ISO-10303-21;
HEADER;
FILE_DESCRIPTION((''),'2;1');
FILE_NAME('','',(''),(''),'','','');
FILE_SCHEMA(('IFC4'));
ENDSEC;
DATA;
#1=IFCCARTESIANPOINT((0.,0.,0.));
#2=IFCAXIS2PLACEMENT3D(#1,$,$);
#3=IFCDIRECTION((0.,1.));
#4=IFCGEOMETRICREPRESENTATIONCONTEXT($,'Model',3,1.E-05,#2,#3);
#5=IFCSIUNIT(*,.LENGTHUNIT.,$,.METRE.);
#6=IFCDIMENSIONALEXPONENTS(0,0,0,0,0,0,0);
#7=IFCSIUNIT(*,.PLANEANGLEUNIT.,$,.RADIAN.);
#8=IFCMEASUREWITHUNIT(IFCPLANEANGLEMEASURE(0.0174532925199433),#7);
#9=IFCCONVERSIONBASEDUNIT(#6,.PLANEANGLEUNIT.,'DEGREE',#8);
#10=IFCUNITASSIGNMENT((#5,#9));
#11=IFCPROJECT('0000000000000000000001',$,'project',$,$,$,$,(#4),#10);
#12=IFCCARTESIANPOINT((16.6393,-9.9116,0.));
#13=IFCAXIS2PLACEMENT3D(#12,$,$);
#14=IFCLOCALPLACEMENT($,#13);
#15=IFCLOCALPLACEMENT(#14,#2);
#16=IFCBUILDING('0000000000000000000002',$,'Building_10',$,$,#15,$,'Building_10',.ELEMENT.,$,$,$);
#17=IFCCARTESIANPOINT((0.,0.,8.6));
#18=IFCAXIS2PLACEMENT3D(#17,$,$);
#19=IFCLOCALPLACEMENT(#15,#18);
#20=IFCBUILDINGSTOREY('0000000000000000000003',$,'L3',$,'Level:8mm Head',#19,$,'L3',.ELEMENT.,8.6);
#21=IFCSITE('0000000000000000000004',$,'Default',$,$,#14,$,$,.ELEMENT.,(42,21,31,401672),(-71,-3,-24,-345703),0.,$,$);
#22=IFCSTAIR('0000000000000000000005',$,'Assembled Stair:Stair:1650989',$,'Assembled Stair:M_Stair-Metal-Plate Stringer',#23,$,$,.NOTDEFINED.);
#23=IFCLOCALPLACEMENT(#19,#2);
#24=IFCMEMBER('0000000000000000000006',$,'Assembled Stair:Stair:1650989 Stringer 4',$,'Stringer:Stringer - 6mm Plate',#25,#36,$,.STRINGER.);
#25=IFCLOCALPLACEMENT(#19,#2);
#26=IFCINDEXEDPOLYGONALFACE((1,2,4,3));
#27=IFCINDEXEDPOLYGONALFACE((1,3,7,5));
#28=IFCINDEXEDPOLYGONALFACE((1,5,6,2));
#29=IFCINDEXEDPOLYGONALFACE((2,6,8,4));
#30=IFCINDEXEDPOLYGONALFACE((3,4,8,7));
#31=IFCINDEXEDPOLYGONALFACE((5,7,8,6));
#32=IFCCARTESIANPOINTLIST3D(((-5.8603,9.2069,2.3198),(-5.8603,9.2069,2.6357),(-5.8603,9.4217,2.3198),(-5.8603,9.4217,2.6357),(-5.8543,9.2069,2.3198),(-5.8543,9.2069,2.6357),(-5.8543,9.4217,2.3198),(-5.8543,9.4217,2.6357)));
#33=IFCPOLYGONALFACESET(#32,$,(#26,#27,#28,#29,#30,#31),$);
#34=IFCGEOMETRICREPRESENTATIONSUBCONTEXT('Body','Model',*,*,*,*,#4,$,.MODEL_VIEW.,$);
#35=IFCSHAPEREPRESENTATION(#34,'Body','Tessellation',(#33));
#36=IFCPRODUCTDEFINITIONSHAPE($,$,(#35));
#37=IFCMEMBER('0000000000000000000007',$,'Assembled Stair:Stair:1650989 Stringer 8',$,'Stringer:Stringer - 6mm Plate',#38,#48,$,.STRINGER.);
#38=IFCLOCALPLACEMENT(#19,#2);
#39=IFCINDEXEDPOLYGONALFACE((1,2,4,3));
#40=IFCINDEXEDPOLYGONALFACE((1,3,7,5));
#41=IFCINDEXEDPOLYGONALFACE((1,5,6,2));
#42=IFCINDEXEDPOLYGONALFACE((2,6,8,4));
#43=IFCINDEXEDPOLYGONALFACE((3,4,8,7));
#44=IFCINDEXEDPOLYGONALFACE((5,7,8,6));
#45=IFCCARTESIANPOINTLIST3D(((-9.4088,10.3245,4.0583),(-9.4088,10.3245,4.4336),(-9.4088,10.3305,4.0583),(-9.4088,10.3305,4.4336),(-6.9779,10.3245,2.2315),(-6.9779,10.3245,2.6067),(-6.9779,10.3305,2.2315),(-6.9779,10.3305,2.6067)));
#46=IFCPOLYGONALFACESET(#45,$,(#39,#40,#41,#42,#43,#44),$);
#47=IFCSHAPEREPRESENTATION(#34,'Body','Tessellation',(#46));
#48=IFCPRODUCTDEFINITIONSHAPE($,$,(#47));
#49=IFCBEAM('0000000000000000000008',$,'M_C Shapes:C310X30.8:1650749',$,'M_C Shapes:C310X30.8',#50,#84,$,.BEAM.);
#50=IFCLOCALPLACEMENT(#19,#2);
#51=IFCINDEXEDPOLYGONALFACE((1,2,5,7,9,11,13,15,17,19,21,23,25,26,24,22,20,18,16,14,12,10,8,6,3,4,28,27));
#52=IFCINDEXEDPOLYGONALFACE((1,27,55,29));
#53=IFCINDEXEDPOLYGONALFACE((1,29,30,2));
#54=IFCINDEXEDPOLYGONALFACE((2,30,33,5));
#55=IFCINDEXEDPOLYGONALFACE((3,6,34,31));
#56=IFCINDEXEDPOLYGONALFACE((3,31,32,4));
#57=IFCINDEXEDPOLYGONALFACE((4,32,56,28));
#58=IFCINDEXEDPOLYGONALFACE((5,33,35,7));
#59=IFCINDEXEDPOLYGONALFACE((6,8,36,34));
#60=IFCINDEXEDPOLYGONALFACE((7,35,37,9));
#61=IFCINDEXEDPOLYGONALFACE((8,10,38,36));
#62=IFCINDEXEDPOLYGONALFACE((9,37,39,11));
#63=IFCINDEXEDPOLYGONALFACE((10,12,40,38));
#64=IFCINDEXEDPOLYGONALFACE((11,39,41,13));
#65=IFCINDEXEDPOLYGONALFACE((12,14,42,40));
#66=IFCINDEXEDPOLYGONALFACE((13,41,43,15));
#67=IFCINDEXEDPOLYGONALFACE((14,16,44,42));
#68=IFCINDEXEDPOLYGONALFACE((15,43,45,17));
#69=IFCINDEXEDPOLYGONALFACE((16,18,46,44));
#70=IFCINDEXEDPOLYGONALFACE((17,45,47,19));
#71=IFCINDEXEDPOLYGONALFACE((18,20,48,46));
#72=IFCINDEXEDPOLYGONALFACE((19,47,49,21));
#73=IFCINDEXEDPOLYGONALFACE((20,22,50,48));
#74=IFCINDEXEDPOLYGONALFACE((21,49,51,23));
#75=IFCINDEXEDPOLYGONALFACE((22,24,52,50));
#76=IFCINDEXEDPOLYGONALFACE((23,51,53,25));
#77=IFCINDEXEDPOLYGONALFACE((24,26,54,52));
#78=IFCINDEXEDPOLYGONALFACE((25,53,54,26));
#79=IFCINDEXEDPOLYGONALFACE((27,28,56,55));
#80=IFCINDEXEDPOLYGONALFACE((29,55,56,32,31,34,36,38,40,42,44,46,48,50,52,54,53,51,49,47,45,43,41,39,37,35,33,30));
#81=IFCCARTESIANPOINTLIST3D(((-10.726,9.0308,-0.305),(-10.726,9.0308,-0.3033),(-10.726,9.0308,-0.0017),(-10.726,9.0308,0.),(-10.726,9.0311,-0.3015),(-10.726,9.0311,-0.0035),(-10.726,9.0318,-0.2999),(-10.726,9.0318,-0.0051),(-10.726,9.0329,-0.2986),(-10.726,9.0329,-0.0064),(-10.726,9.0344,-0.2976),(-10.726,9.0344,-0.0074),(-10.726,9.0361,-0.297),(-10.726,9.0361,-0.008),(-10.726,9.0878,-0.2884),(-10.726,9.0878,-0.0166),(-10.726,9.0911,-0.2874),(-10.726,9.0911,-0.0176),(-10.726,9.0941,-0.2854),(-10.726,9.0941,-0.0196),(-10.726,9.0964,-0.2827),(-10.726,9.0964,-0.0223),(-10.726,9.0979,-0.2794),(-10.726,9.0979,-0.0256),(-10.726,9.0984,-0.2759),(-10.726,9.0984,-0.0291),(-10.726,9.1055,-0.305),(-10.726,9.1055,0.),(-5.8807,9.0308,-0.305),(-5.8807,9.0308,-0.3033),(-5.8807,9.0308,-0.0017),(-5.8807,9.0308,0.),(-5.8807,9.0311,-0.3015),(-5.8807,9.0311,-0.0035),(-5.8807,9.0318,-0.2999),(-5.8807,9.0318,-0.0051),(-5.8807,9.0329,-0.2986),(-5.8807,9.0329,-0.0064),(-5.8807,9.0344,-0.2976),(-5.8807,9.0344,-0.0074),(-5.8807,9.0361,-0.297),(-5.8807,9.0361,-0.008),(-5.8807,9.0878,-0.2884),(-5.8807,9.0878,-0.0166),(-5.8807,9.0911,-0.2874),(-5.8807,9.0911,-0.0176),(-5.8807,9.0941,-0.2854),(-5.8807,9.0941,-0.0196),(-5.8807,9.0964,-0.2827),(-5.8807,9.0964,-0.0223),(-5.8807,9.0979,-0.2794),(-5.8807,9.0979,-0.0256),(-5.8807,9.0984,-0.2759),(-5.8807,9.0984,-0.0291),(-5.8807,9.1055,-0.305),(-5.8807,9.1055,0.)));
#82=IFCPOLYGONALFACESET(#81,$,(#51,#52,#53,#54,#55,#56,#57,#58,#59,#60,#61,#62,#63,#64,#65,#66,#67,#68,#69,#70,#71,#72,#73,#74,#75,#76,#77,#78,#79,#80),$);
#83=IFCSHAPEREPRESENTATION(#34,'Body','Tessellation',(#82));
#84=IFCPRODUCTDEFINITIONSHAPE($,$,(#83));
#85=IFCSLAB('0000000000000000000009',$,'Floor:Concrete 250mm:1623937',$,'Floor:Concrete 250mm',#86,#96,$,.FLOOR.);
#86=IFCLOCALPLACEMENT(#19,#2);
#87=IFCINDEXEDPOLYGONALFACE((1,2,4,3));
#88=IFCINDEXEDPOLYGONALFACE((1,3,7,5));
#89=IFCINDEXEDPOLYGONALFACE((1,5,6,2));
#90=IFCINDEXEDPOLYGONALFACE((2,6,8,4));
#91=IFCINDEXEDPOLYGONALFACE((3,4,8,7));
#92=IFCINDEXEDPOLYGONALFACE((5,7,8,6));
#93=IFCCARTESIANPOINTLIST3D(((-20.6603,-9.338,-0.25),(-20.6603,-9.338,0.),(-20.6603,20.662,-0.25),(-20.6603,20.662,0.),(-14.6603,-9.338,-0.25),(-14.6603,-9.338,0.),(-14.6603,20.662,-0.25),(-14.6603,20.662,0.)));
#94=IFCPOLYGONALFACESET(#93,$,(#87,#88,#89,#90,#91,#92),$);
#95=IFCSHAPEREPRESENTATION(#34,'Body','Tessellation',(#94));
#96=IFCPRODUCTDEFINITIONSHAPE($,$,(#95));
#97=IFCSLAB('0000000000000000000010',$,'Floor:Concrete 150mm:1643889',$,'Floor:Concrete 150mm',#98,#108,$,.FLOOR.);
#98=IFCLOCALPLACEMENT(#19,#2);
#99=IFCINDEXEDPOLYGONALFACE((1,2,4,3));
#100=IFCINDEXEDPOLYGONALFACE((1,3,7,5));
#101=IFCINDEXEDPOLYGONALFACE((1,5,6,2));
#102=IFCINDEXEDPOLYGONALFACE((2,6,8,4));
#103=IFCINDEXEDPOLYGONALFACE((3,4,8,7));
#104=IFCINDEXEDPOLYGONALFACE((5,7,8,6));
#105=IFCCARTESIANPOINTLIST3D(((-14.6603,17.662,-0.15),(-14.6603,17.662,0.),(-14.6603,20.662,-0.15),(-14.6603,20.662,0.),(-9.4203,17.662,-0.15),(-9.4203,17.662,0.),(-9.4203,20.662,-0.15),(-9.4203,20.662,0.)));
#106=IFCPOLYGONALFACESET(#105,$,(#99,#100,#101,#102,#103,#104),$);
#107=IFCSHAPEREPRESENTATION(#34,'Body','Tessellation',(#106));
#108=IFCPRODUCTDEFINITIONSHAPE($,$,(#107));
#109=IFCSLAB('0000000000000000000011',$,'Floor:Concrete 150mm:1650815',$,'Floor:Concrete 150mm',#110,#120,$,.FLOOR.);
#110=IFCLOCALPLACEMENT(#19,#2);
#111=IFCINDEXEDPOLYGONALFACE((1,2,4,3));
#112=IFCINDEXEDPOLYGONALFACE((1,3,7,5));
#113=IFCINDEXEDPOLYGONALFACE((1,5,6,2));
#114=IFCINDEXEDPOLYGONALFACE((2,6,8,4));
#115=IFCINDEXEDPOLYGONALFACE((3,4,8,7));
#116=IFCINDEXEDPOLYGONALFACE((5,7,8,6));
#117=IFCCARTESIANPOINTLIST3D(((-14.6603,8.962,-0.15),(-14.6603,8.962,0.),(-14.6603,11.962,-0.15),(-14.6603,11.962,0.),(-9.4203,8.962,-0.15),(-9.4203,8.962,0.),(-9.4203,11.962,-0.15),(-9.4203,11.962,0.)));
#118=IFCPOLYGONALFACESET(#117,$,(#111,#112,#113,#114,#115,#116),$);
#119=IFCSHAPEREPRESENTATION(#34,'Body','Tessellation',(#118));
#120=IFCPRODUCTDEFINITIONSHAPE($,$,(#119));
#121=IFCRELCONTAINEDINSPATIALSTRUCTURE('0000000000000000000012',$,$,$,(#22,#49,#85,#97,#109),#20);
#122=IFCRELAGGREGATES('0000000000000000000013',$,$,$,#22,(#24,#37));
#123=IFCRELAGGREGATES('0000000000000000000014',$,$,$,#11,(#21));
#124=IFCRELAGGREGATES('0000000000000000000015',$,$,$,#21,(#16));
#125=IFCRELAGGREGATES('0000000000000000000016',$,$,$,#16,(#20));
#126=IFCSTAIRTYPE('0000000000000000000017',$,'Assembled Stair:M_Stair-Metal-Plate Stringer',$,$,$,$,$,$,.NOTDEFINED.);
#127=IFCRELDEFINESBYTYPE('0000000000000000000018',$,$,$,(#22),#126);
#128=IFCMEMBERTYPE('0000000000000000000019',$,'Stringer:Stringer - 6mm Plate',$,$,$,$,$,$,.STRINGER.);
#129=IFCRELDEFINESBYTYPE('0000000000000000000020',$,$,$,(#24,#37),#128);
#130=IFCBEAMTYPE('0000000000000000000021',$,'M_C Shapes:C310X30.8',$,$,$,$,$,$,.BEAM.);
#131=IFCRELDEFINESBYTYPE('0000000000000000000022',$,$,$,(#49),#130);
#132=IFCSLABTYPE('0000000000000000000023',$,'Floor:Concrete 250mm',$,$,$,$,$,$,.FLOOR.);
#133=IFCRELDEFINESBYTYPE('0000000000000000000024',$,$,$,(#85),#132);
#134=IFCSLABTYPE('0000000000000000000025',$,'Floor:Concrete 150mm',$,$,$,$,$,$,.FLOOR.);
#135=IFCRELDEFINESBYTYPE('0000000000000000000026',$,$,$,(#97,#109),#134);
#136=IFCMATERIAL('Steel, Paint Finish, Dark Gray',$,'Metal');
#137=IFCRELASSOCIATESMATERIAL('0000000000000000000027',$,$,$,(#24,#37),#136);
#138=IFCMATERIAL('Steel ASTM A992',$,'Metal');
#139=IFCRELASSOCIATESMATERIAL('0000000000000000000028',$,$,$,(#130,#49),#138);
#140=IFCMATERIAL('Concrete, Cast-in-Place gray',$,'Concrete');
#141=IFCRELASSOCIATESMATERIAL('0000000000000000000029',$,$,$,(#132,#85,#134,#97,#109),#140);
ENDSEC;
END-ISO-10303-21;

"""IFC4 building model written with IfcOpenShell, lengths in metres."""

from ifc_helpers import new_model, entity, si_unit, converted_unit, direction, frame, origin, place, context, subcontext, project, spatial, line, arc, indexed_curve, outline, extrude, source, transform, mapped, material, type_object, type_shapes, element, aggregate, save


model = new_model("IFC4")

# Units and contexts
model_context = context("Model", 3, precision=1e-05, world=origin(), true_north=direction((0.0, 1.0)))
body_context = subcontext(model_context, "Body", "Model", "MODEL_VIEW")
ifc_project = project(units=[si_unit("LENGTHUNIT", "METRE"), converted_unit("PLANEANGLEUNIT", "DEGREE", entity("IfcPlaneAngleMeasure", 0.0174532925199433), si_unit("PLANEANGLEUNIT", "RADIAN"), dimensions=[0, 0, 0, 0, 0, 0, 0])], contexts=[model_context])

# Site, building, storey
site_placement = place(None, frame((16.6393, -9.9116, 0.0)))
site = spatial("IfcSite", under=ifc_project, at=site_placement, Name="Default", CompositionType="ELEMENT", RefLatitude=(42, 21, 31, 401672), RefLongitude=(-71, -3, -24, -345703), RefElevation=0.0)
building_placement = place(site_placement, origin())
building = spatial("IfcBuilding", under=site, at=building_placement, Name="Building_10", LongName="Building_10", CompositionType="ELEMENT")
storey_placement = place(building_placement, frame((0.0, 0.0, 8.6)))
storey = spatial("IfcBuildingStorey", under=building, at=storey_placement, Name="L3", ObjectType="Level:8mm Head", LongName="L3", CompositionType="ELEMENT", Elevation=8.6)

# Shared definitions
ifc_material_1 = material(Name="Steel ASTM A992", Category="Metal")

# Stair, members
stair_type = type_object("IfcStairType", Name="Assembled Stair:M_Stair-Metal-Plate Stringer", PredefinedType="NOTDEFINED")
ifc_material_2 = material(Name="Steel, Paint Finish, Dark Gray", Category="Metal")
member_type = type_object("IfcMemberType", Name="Stringer:Stringer - 6mm Plate", PredefinedType="STRINGER")
stair_1_placement = place(storey_placement, origin())
stair_1 = element("IfcStair", 1, at=stair_1_placement, inside=storey, type_object=stair_type, Name="Assembled Stair:Stair:1650989", ObjectType="Assembled Stair:M_Stair-Metal-Plate Stringer", PredefinedType="NOTDEFINED")
member_1_placement = place(stair_1_placement, origin())
member_1 = element("IfcMember", 2, at=member_1_placement, type_object=member_type, material=ifc_material_2, Name="Assembled Stair:Stair:1650989 Stringer 4", ObjectType="Stringer:Stringer - 6mm Plate", PredefinedType="STRINGER", context=body_context, shape_type="SweptSolid", body=[
    extrude(outline(indexed_curve([(-0.1074, -0.003), (0.1074, -0.003), (0.1074, 0.003), (-0.1074, 0.003), (-0.1074, -0.003)], self_intersect=False)), frame((-5.8573, 9.3143, 2.3198), z_axis=(0.0, 0.0, 1.0), x_axis=(0.0, -1.0, 0.0)), (0.0, 0.0, 1.0), 0.3159),
])
member_2_placement = place(stair_1_placement, origin())
member_2 = element("IfcMember", 3, at=member_2_placement, type_object=member_type, material=ifc_material_2, Name="Assembled Stair:Stair:1650989 Stringer 8", ObjectType="Stringer:Stringer - 6mm Plate", PredefinedType="STRINGER", context=body_context, shape_type="SweptSolid", body=[
    extrude(outline(indexed_curve([(-1.6331, -0.15), (1.4077, -0.15), (1.6331, 0.15), (-1.4077, 0.15), (-1.6331, -0.15)], self_intersect=False)), frame((-8.1933, 10.3245, 3.3325), z_axis=(0.0, 1.0, 0.0), x_axis=(-0.799415, 0.0, 0.600779)), (0.0, 0.0, 1.0), 0.006),
])
aggregate(stair_1, [member_1, member_2])

# Beam
beam_type = type_object("IfcBeamType", Name="M_C Shapes:C310X30.8", PredefinedType="BEAM", material=ifc_material_1)
shared_shape_1 = source(origin(), body_context, "Body", "SweptSolid", [
    extrude(outline(indexed_curve([(-0.0406, -0.1525), (0.0341, -0.1525), (0.0341, -0.1508), (0.0326, -0.1467), (0.0288, -0.1445), (-0.0228, -0.1359), (-0.0305, -0.1316), (-0.0335, -0.1234), (-0.0335, 0.1234), (-0.0305, 0.1316), (-0.0228, 0.1359), (0.0288, 0.1445), (0.0326, 0.1467), (0.0341, 0.1508), (0.0341, 0.1525), (-0.0406, 0.1525)], segments=[line(1, 2, 3), arc(3, 4, 5), line(5, 6), arc(6, 7, 8), line(8, 9), arc(9, 10, 11), line(11, 12), arc(12, 13, 14), line(14, 15, 16, 1)], self_intersect=False)), frame((-2.4226, -0.0229, 0.0), z_axis=(1.0, 0.0, 0.0), x_axis=(0.0, -1.0, 0.0)), (0.0, 0.0, 1.0), 4.8453),
])
type_shapes(beam_type, [shared_shape_1])
beam_placement = place(storey_placement, frame((-8.3033, 9.0878, -0.1525)))
element("IfcBeam", 4, at=beam_placement, inside=storey, type_object=beam_type, material=ifc_material_1, Name="M_C Shapes:C310X30.8:1650749", ObjectType="M_C Shapes:C310X30.8", PredefinedType="BEAM", context=body_context, shape_type="MappedRepresentation", body=[
    mapped(shared_shape_1, transform((0.0, 0.0, 0.0), scale=1.0)),
])

# Slabs
ifc_material_3 = material(Name="Concrete, Cast-in-Place gray", Category="Concrete")
slab_type_1 = type_object("IfcSlabType", Name="Floor:Concrete 250mm", PredefinedType="FLOOR", material=ifc_material_3)
slab_1_placement = place(storey_placement, origin())
element("IfcSlab", 5, at=slab_1_placement, inside=storey, type_object=slab_type_1, material=ifc_material_3, Name="Floor:Concrete 250mm:1623937", ObjectType="Floor:Concrete 250mm", PredefinedType="FLOOR", context=body_context, shape_type="SweptSolid", body=[
    extrude(outline(indexed_curve([(-15.0, -3.0), (15.0, -3.0), (15.0, 3.0), (-15.0, 3.0), (-15.0, -3.0)], self_intersect=False)), frame((-17.6603, 5.662, 0.0), z_axis=(0.0, 0.0, -1.0), x_axis=(0.0, 1.0, 0.0)), (0.0, 0.0, 1.0), 0.25),
])
slab_type_2 = type_object("IfcSlabType", Name="Floor:Concrete 150mm", PredefinedType="FLOOR", material=ifc_material_3)
slab_2_placement = place(storey_placement, origin())
element("IfcSlab", 6, at=slab_2_placement, inside=storey, type_object=slab_type_2, material=ifc_material_3, Name="Floor:Concrete 150mm:1643889", ObjectType="Floor:Concrete 150mm", PredefinedType="FLOOR", context=body_context, shape_type="SweptSolid", body=[
    extrude(outline(indexed_curve([(-1.5, -2.62), (1.5, -2.62), (1.5, 2.62), (-1.5, 2.62), (-1.5, -2.62)], self_intersect=False)), frame((-12.0403, 19.162, 0.0), z_axis=(0.0, 0.0, -1.0), x_axis=(0.0, 1.0, 0.0)), (0.0, 0.0, 1.0), 0.15),
])
slab_3_placement = place(storey_placement, origin())
element("IfcSlab", 7, at=slab_3_placement, inside=storey, type_object=slab_type_2, material=ifc_material_3, Name="Floor:Concrete 150mm:1650815", ObjectType="Floor:Concrete 150mm", PredefinedType="FLOOR", context=body_context, shape_type="SweptSolid", body=[
    extrude(outline(indexed_curve([(-1.5, -2.62), (1.5, -2.62), (1.5, 2.62), (-1.5, 2.62), (-1.5, -2.62)], self_intersect=False)), frame((-12.0403, 10.462, 0.0), z_axis=(0.0, 0.0, -1.0), x_axis=(0.0, 1.0, 0.0)), (0.0, 0.0, 1.0), 0.15),
])

save(model, "model.ifc")
